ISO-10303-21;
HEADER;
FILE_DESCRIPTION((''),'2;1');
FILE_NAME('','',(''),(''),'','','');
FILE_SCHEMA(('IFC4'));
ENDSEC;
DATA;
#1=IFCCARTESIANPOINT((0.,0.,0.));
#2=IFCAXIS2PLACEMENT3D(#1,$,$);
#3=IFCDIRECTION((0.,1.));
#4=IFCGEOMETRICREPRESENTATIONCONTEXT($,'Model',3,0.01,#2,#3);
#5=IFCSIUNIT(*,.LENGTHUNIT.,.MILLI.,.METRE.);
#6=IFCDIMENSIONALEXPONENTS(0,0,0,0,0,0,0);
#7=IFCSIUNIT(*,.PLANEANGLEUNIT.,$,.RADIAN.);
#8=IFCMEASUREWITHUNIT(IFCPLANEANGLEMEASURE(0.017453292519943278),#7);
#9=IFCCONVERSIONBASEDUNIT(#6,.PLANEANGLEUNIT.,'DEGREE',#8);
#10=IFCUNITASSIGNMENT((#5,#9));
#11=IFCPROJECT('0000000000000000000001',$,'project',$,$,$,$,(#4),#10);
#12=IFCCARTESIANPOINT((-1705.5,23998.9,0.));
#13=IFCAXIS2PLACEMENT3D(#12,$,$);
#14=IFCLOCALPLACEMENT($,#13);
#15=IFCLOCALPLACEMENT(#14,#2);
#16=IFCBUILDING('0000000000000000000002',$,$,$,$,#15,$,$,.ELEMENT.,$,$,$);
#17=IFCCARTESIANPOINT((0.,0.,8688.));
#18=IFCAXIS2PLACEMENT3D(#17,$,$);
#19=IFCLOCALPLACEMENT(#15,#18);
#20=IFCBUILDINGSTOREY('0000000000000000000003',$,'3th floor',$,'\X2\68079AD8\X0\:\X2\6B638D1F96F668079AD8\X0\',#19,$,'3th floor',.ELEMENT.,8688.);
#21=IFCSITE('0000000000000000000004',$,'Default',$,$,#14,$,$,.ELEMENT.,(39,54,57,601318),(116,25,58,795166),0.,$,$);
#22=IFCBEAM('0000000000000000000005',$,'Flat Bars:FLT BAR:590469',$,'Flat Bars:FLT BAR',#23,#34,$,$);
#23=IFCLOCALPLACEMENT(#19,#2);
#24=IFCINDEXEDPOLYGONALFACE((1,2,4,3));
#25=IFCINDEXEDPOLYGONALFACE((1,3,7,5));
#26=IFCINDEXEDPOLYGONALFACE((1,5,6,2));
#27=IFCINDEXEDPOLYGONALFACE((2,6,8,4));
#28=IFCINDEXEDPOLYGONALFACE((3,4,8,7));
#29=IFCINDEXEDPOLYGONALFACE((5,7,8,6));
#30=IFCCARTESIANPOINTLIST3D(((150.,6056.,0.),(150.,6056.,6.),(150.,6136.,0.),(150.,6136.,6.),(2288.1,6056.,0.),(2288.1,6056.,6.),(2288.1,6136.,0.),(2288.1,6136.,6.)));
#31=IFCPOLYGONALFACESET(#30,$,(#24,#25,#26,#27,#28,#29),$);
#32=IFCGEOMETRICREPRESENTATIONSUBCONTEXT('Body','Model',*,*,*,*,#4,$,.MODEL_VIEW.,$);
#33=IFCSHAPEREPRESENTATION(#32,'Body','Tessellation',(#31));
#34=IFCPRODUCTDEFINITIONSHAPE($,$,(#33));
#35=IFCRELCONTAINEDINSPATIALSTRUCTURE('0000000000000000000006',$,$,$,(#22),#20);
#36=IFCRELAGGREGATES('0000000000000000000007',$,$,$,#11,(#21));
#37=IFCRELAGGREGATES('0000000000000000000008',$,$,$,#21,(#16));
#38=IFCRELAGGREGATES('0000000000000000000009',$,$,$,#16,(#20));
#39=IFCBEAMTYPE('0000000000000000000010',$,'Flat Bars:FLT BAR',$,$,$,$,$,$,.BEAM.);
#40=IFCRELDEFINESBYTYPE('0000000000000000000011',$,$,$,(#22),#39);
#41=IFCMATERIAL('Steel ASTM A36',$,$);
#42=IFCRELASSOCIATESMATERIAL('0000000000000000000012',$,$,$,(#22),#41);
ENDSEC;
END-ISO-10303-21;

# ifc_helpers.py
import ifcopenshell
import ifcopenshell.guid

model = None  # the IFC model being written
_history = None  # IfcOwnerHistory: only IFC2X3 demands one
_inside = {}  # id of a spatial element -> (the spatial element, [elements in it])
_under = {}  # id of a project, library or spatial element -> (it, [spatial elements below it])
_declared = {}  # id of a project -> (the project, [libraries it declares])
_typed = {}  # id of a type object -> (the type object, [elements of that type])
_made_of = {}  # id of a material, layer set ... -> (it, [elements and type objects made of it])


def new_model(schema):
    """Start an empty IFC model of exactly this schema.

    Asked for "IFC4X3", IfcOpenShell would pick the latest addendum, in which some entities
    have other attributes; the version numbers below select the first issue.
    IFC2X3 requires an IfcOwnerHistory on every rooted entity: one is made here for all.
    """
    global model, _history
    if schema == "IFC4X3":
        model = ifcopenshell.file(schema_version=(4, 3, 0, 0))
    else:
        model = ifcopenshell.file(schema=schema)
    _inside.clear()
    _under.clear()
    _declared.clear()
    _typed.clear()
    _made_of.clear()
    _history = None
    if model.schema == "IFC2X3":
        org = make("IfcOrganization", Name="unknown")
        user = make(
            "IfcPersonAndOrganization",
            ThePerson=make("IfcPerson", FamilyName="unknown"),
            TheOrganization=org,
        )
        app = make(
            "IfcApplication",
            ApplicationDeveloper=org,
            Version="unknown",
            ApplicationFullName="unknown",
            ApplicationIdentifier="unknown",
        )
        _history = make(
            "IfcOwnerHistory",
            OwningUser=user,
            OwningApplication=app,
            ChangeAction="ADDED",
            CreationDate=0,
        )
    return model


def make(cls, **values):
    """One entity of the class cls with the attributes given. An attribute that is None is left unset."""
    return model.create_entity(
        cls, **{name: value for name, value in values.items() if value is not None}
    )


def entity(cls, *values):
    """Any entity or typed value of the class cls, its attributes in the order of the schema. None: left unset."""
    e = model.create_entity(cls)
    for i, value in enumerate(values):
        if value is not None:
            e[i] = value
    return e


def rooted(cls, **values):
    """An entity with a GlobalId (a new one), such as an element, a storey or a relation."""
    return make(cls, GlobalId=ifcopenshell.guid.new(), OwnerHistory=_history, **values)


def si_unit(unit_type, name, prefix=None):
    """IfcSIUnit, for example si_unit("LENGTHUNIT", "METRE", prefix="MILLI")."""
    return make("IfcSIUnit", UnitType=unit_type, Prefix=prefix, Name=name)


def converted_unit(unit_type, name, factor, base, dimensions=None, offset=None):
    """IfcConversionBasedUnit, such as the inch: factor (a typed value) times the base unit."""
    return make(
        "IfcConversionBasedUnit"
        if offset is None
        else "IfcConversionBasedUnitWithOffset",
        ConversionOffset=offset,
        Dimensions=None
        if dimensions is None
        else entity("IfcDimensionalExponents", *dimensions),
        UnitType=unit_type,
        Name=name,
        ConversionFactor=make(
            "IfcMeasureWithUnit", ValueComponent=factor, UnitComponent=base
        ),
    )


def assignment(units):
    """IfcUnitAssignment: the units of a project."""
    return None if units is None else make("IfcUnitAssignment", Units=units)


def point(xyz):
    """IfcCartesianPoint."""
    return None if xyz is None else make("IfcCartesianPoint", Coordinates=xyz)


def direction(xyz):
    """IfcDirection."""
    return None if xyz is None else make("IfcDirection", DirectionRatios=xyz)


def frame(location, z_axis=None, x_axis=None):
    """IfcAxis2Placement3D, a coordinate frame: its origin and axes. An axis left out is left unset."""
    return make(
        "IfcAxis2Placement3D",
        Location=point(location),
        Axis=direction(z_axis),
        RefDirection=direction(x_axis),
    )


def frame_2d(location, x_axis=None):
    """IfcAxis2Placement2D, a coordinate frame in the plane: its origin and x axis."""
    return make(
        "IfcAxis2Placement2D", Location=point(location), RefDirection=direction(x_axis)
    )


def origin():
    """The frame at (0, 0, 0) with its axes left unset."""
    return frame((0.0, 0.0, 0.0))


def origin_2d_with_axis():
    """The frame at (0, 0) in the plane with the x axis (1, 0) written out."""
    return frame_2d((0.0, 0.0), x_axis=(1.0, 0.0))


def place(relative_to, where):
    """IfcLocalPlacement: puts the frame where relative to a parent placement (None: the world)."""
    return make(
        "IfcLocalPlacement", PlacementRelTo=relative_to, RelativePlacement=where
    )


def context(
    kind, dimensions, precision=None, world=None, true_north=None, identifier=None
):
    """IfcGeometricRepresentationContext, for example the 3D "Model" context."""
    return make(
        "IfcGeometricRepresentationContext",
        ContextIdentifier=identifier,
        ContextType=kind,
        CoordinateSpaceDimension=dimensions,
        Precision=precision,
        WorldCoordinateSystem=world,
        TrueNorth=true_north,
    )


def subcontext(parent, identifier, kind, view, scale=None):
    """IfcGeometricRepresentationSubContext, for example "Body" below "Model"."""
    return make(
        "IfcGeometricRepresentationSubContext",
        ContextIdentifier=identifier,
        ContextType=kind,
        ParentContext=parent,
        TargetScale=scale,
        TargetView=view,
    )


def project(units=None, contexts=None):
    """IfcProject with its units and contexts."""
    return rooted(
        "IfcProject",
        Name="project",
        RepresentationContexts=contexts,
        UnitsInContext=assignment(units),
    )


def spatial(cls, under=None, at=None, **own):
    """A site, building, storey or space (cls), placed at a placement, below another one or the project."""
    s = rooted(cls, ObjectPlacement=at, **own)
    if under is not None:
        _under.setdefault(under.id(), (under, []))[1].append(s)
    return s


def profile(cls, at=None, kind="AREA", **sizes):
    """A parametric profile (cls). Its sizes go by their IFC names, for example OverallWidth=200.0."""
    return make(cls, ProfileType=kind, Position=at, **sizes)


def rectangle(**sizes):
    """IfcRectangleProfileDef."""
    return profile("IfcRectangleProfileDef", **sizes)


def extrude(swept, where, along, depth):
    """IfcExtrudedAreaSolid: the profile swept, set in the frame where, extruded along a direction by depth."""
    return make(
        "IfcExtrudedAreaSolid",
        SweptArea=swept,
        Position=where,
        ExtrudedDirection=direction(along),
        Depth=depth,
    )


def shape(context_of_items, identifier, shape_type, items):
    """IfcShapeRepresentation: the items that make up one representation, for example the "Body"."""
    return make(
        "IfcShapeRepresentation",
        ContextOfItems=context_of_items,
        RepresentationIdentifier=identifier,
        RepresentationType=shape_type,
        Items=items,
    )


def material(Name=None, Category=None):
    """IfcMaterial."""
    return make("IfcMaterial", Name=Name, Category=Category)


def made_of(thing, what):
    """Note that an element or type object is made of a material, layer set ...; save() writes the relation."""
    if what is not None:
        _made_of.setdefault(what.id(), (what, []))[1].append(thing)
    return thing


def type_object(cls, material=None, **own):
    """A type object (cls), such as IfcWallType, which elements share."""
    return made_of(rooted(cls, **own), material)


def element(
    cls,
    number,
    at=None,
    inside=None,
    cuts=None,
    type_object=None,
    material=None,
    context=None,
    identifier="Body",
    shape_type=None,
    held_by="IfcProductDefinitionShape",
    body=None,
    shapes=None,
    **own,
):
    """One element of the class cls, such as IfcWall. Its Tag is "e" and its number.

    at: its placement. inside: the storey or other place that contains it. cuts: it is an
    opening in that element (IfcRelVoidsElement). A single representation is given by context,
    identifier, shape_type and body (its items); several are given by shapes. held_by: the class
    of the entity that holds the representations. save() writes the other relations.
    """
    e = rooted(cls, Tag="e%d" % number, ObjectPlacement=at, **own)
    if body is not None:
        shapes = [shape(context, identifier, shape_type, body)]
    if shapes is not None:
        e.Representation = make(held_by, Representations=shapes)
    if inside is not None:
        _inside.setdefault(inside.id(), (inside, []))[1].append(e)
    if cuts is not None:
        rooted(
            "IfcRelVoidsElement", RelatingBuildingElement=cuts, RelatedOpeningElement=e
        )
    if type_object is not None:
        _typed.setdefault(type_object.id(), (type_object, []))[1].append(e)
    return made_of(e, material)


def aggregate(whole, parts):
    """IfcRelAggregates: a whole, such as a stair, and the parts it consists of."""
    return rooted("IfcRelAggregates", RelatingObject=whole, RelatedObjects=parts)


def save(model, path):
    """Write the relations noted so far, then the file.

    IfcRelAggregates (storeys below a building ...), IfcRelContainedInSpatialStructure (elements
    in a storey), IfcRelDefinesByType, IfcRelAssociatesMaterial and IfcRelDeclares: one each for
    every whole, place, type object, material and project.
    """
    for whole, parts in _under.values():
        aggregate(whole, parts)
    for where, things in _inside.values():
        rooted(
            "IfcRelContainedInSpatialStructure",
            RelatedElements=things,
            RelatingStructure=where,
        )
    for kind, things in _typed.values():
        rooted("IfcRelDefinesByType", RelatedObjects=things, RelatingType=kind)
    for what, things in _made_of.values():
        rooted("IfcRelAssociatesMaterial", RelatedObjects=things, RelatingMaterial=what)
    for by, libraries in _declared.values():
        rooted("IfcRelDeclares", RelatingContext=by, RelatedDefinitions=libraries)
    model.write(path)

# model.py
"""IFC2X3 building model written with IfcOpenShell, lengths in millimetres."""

from ifc_helpers import new_model, entity, si_unit, converted_unit, direction, frame, origin, origin_2d_with_axis, place, context, subcontext, project, spatial, rectangle, extrude, material, type_object, element, save


model = new_model("IFC2X3")

# Units and contexts
model_context = context("Model", 3, precision=0.01, world=origin(), true_north=direction((0.0, 1.0)))
body_context = subcontext(model_context, "Body", "Model", "MODEL_VIEW")
ifc_project = project(units=[si_unit("LENGTHUNIT", "METRE", prefix="MILLI"), converted_unit("PLANEANGLEUNIT", "DEGREE", entity("IfcPlaneAngleMeasure", 0.017453292519943278), si_unit("PLANEANGLEUNIT", "RADIAN"), dimensions=[0, 0, 0, 0, 0, 0, 0])], contexts=[model_context])

# Site, building, storey
site_placement = place(None, frame((-1705.5, 23998.9, 0.0)))
site = spatial("IfcSite", under=ifc_project, at=site_placement, Name="Default", CompositionType="ELEMENT", RefLatitude=(39, 54, 57, 601318), RefLongitude=(116, 25, 58, 795166), RefElevation=0.0)
building_placement = place(site_placement, origin())
building = spatial("IfcBuilding", under=site, at=building_placement, CompositionType="ELEMENT")
storey_placement = place(building_placement, frame((0.0, 0.0, 8688.0)))
storey = spatial("IfcBuildingStorey", under=building, at=storey_placement, Name="3th floor", ObjectType="标高:正负零标高", LongName="3th floor", CompositionType="ELEMENT", Elevation=8688.0)

# Beam
ifc_material_1 = material(Name="Steel ASTM A36")
beam_type = type_object("IfcBeamType", Name="Flat Bars:FLT BAR", PredefinedType="BEAM")
for number, where, name in (
    (1, (150.0, 6096.0, 6.0), "Flat Bars:FLT BAR:590469"),
):
    element("IfcBeam", number, at=place(storey_placement, frame(where)), inside=storey, type_object=beam_type, material=ifc_material_1, Name=name, ObjectType="Flat Bars:FLT BAR", context=body_context, shape_type="SweptSolid", body=[
        extrude(rectangle(XDim=6.0, YDim=80.0, at=origin_2d_with_axis()), frame((0.0, 0.0, -3.0), z_axis=(1.0, 0.0, 0.0), x_axis=(0.0, 0.0, -1.0)), (0.0, 0.0, 1.0), 2138.1),
    ])

save(model, "model.ifc")
